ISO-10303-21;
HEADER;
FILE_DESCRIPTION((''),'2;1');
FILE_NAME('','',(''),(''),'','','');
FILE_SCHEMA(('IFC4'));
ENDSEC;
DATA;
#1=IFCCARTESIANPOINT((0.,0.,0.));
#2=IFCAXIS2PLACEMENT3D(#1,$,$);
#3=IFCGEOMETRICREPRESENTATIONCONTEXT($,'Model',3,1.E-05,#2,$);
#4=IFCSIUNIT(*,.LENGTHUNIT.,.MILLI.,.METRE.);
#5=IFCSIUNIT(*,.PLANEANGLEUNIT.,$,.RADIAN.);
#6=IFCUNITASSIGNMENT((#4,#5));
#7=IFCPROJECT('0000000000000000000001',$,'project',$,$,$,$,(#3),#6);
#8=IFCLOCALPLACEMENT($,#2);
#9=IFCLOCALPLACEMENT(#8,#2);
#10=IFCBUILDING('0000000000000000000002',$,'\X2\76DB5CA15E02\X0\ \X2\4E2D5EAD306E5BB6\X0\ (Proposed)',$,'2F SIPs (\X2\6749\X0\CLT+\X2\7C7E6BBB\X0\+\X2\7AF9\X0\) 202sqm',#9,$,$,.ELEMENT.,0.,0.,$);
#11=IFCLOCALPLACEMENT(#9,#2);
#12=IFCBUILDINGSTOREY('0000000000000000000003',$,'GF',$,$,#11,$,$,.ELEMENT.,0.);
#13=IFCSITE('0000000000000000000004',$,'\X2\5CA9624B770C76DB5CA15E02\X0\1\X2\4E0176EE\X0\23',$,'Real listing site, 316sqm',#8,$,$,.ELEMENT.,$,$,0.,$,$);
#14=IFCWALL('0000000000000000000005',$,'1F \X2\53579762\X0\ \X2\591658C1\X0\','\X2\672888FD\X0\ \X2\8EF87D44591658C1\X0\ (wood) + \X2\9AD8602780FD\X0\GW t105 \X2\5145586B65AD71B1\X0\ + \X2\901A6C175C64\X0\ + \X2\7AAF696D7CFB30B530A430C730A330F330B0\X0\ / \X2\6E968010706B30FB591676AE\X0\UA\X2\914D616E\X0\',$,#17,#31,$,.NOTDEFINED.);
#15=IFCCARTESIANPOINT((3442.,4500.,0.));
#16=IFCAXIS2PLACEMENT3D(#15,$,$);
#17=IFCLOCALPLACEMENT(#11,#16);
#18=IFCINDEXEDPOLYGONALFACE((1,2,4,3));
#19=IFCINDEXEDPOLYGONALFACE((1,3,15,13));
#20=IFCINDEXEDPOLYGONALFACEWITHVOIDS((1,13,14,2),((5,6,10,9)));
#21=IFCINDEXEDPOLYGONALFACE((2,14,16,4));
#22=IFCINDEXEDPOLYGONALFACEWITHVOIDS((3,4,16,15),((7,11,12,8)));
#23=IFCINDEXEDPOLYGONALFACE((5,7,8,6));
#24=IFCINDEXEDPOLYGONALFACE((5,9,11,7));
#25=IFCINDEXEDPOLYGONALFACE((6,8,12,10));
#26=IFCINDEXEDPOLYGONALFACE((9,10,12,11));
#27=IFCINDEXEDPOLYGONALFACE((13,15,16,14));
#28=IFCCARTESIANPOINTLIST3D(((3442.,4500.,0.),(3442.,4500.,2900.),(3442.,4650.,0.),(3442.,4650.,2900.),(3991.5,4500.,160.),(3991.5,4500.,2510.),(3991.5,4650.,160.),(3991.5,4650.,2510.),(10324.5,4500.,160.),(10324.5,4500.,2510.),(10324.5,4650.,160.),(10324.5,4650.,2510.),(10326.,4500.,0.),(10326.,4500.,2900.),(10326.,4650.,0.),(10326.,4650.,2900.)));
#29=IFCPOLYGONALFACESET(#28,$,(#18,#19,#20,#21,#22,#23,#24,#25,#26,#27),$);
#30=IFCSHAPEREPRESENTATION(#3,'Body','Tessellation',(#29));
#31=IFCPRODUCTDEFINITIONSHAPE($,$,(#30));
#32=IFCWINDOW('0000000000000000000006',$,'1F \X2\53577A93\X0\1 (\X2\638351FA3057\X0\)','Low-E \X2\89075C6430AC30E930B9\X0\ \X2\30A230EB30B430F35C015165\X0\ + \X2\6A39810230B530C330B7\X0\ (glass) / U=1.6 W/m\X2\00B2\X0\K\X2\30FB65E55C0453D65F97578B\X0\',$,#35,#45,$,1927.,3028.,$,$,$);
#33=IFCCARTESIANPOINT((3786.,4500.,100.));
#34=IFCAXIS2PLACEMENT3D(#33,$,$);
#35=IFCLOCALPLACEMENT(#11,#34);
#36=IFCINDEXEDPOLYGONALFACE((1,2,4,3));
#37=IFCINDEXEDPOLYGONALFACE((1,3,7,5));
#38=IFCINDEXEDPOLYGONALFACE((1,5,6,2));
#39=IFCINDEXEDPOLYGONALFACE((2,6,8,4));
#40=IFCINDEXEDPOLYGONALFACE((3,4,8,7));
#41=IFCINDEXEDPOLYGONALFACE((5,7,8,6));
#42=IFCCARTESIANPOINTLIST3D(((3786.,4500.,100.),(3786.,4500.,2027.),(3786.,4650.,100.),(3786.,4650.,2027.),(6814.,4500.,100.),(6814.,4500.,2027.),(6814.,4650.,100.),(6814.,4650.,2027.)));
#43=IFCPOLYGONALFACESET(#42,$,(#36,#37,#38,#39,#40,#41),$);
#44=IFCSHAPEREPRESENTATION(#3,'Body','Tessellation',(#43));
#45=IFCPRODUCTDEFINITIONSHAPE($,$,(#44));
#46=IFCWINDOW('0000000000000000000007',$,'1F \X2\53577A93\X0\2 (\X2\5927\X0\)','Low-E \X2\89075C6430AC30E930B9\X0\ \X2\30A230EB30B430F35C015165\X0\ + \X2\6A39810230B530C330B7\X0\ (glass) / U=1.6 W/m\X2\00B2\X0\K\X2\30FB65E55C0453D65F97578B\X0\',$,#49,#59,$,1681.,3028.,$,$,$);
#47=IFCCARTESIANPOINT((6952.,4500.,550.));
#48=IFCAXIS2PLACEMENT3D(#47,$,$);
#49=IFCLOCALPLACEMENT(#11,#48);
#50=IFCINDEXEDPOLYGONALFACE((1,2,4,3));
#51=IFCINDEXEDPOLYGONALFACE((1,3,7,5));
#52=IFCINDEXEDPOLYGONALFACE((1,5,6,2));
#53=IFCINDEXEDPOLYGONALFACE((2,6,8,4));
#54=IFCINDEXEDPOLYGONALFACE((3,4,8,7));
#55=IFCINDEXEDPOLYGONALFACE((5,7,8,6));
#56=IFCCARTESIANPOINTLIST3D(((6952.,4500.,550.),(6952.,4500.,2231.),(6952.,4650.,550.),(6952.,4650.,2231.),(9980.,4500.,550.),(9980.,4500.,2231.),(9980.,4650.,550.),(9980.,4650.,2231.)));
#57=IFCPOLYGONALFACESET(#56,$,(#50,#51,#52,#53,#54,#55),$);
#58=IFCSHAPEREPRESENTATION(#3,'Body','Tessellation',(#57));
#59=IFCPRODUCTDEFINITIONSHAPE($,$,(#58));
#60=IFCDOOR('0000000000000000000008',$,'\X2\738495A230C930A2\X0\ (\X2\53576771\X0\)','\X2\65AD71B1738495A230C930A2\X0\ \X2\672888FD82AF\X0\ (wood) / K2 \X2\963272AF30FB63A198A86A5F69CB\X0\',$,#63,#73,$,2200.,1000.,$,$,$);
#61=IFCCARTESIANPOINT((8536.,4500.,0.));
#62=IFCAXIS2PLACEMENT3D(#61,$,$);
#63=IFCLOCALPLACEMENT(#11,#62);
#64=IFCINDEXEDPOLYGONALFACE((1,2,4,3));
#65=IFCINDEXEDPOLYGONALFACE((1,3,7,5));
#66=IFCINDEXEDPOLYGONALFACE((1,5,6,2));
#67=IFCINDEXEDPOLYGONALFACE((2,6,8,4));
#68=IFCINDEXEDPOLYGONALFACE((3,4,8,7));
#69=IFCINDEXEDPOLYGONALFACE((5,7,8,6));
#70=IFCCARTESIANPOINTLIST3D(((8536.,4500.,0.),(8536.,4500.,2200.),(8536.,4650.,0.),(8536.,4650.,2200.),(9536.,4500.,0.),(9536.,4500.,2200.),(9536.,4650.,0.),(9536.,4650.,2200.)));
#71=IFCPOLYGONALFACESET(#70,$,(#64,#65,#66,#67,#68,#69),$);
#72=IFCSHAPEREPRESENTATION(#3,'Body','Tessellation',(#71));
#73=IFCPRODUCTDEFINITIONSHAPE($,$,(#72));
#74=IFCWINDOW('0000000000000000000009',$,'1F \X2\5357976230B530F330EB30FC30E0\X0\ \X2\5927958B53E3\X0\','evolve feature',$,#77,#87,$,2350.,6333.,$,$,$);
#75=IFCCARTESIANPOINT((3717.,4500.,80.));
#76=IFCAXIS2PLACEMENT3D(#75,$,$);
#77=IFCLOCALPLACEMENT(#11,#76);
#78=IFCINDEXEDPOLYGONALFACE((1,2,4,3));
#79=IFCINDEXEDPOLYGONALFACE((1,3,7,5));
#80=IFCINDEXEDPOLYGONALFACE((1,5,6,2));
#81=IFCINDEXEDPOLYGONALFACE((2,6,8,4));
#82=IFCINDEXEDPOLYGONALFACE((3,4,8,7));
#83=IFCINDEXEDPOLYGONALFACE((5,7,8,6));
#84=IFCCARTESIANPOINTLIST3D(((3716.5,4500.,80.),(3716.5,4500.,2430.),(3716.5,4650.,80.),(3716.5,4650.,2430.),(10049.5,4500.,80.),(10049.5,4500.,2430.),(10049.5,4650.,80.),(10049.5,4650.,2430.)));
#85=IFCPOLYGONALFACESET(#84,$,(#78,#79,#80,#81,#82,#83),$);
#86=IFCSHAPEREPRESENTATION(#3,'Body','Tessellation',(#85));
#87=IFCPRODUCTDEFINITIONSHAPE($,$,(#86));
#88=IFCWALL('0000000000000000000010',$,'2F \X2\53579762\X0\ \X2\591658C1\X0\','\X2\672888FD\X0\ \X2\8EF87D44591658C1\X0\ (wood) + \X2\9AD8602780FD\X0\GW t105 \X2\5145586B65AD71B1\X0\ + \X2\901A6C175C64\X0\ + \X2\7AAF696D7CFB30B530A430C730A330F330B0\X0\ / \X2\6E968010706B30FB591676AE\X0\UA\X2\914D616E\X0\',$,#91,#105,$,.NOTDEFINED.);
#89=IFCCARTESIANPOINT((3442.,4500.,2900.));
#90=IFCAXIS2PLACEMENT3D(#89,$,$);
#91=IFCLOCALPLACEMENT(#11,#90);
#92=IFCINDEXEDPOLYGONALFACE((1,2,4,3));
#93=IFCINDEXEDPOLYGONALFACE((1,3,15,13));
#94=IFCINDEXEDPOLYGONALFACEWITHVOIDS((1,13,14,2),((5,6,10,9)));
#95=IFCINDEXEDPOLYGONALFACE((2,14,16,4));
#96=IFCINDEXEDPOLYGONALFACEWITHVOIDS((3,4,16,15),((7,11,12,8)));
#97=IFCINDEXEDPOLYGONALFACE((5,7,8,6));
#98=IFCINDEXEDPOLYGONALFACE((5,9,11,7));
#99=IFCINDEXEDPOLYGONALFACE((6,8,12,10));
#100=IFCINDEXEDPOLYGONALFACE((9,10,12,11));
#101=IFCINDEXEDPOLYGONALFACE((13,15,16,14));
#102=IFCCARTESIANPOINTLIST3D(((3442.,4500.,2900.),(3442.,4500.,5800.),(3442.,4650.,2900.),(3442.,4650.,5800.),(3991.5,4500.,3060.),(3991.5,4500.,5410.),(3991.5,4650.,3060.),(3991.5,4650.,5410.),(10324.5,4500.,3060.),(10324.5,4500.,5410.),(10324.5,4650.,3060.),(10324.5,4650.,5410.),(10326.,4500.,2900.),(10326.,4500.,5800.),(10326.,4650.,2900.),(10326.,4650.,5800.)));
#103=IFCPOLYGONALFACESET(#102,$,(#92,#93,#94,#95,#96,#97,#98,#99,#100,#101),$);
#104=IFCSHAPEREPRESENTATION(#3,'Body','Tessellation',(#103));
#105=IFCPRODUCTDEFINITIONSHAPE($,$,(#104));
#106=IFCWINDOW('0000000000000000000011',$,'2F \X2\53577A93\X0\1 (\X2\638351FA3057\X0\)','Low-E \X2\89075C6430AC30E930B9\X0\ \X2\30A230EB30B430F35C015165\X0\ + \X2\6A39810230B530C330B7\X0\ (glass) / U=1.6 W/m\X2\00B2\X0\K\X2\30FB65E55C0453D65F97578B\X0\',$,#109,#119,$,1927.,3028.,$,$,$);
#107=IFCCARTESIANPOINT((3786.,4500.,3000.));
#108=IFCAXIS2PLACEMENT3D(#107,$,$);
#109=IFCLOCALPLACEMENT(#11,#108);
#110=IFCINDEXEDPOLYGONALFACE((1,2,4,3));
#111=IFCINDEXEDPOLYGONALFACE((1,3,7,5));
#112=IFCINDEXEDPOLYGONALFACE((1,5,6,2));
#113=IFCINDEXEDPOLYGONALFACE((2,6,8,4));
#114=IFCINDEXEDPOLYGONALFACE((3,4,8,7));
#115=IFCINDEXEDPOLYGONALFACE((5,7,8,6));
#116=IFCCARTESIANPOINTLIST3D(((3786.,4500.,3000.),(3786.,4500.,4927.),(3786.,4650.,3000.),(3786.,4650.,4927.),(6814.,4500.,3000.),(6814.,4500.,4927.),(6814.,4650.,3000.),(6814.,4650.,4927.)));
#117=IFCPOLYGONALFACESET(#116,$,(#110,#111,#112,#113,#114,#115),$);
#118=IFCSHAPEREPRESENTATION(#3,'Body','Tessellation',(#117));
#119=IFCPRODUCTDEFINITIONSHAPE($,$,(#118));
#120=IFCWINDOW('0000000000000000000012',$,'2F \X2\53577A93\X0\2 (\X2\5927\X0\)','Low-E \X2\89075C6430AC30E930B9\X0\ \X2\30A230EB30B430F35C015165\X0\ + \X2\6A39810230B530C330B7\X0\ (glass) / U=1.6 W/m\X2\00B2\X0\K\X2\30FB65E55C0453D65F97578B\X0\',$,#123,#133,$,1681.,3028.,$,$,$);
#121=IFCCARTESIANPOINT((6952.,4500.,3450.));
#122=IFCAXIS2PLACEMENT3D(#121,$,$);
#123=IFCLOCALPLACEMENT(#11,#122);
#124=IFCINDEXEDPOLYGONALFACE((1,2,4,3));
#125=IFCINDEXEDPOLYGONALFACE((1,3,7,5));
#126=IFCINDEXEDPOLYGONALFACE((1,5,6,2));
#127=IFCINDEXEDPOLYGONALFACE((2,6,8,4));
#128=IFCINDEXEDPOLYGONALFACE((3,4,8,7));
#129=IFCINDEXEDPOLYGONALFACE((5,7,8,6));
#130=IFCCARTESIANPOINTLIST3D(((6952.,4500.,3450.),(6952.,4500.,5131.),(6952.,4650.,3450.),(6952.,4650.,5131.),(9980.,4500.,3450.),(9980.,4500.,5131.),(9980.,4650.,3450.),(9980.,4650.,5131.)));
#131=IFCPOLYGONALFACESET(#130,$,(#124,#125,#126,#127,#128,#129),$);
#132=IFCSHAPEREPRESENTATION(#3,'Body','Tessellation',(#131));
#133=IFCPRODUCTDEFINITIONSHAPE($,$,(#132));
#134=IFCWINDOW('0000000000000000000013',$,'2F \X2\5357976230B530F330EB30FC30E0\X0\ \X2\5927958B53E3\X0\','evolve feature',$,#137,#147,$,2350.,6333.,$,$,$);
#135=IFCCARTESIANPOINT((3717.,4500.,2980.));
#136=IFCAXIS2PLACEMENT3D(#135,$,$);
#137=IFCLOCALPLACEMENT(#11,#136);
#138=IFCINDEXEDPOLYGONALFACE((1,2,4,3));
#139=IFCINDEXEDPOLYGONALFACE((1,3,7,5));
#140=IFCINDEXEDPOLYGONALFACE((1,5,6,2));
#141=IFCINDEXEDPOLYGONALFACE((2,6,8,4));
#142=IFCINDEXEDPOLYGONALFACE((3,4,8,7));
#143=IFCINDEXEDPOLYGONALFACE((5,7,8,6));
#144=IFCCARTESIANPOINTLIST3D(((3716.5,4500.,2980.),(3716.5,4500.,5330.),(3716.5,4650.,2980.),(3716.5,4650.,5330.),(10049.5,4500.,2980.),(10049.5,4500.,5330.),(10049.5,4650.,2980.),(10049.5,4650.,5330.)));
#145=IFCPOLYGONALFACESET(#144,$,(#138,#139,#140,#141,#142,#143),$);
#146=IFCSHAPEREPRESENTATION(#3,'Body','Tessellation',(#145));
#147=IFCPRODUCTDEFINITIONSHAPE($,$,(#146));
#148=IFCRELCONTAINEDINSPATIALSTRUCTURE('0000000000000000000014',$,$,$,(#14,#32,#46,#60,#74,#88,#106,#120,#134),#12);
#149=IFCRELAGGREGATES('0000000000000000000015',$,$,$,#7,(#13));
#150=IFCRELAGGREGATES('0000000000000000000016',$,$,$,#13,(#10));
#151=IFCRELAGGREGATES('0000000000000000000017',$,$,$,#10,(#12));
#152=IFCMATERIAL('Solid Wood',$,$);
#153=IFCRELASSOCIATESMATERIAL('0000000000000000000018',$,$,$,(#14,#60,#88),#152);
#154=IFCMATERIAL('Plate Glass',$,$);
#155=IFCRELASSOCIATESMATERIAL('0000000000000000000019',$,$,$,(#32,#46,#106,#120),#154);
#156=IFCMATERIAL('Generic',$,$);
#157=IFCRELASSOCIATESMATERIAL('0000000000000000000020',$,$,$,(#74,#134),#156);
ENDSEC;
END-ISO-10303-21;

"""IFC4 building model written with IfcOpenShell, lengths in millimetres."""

from ifc_helpers import new_model, si_unit, frame, frame_2d, origin, place, context, project, spatial, rectangle, extrude, material, element, fill, save


model = new_model("IFC4")

# Units and contexts
model_context = context("Model", 3, precision=1e-05, world=origin())
ifc_project = project(units=[si_unit("LENGTHUNIT", "METRE", prefix="MILLI"), si_unit("PLANEANGLEUNIT", "RADIAN")], contexts=[model_context])

# Site, building, storey
site_placement = place(None, origin())
site = spatial("IfcSite", under=ifc_project, at=site_placement, Name="岩手県盛岡市1丁目23", ObjectType="Real listing site, 316sqm", CompositionType="ELEMENT", RefElevation=0.0)
building_placement = place(site_placement, origin())
building = spatial("IfcBuilding", under=site, at=building_placement, Name="盛岡市 中庭の家 (Proposed)", ObjectType="2F SIPs (杉CLT+籾殻+竹) 202sqm", CompositionType="ELEMENT", ElevationOfRefHeight=0.0, ElevationOfTerrain=0.0)
storey_placement = place(building_placement, origin())
storey = spatial("IfcBuildingStorey", under=building, at=storey_placement, Name="GF", CompositionType="ELEMENT", Elevation=0.0)

# Shared definitions
ifc_material_1 = material(Name="Solid Wood")

# Wall, openings, windows, door
wall_1_placement = place(storey_placement, frame((3442.0, 4500.0, 0.0)))
wall_1 = element("IfcWall", 1, at=wall_1_placement, inside=storey, material=ifc_material_1, Name="1F 南面 外壁", Description="木製 軸組外壁 (wood) + 高性能GW t105 充填断熱 + 通気層 + 窯業系サイディング / 準耐火・外皮UA配慮", PredefinedType="NOTDEFINED", context=model_context, shape_type="SweptSolid", body=[
    extrude(rectangle(XDim=6884.0, YDim=150.0, at=frame_2d((3442.0, 75.0))), frame((3442.0, 4500.0, 0.0)), (0.0, 0.0, 1.0), 2900.0),
])
opening_1_placement = place(storey_placement, frame((3786.0, 4500.0, 100.0)))
opening_1 = element("IfcOpeningElement", 2, at=opening_1_placement, cuts=wall_1, PredefinedType="NOTDEFINED", context=model_context, shape_type="SweptSolid", body=[
    extrude(rectangle(XDim=3028.0, YDim=150.0, at=frame_2d((1514.0, 75.0))), frame((3786.0, 4500.0, 100.0)), (0.0, 0.0, 1.0), 1927.0),
])
opening_2_placement = place(storey_placement, frame((6952.0, 4500.0, 550.0)))
opening_2 = element("IfcOpeningElement", 3, at=opening_2_placement, cuts=wall_1, PredefinedType="NOTDEFINED", context=model_context, shape_type="SweptSolid", body=[
    extrude(rectangle(XDim=3028.0, YDim=150.0, at=frame_2d((1514.0, 75.0))), frame((6952.0, 4500.0, 550.0)), (0.0, 0.0, 1.0), 1681.0),
])
opening_3_placement = place(storey_placement, frame((8536.0, 4500.0, 0.0)))
opening_3 = element("IfcOpeningElement", 4, at=opening_3_placement, cuts=wall_1, PredefinedType="NOTDEFINED", context=model_context, shape_type="SweptSolid", body=[
    extrude(rectangle(XDim=1000.0, YDim=150.0, at=frame_2d((500.0, 75.0))), frame((8536.0, 4500.0, 0.0)), (0.0, 0.0, 1.0), 2200.0),
])
opening_4_placement = place(storey_placement, frame((3717.0, 4500.0, 80.0)))
opening_4 = element("IfcOpeningElement", 5, at=opening_4_placement, cuts=wall_1, PredefinedType="NOTDEFINED", context=model_context, shape_type="SweptSolid", body=[
    extrude(rectangle(XDim=6333.0, YDim=150.0, at=frame_2d((3166.0, 75.0))), frame((3717.0, 4500.0, 80.0)), (0.0, 0.0, 1.0), 2350.0),
])
ifc_material_2 = material(Name="Plate Glass")
window_1_placement = place(storey_placement, frame((3786.0, 4500.0, 100.0)))
window_1 = element("IfcWindow", 6, at=window_1_placement, inside=storey, material=ifc_material_2, Name="1F 南窓1 (掃出し)", Description="Low-E 複層ガラス アルゴン封入 + 樹脂サッシ (glass) / U=1.6 W/m²K・日射取得型", OverallHeight=1927.0, OverallWidth=3028.0, context=model_context, shape_type="SweptSolid", body=[
    extrude(rectangle(XDim=3028.0, YDim=150.0, at=frame_2d((1514.0, 75.0))), frame((3786.0, 4500.0, 100.0)), (0.0, 0.0, 1.0), 1927.0),
])
fill(opening_1, window_1)
window_2_placement = place(storey_placement, frame((6952.0, 4500.0, 550.0)))
window_2 = element("IfcWindow", 7, at=window_2_placement, inside=storey, material=ifc_material_2, Name="1F 南窓2 (大)", Description="Low-E 複層ガラス アルゴン封入 + 樹脂サッシ (glass) / U=1.6 W/m²K・日射取得型", OverallHeight=1681.0, OverallWidth=3028.0, context=model_context, shape_type="SweptSolid", body=[
    extrude(rectangle(XDim=3028.0, YDim=150.0, at=frame_2d((1514.0, 75.0))), frame((6952.0, 4500.0, 550.0)), (0.0, 0.0, 1.0), 1681.0),
])
fill(opening_2, window_2)
door_placement = place(storey_placement, frame((8536.0, 4500.0, 0.0)))
door = element("IfcDoor", 8, at=door_placement, inside=storey, material=ifc_material_1, Name="玄関ドア (南東)", Description="断熱玄関ドア 木製芯 (wood) / K2 防犯・採風機構", OverallHeight=2200.0, OverallWidth=1000.0, context=model_context, shape_type="SweptSolid", body=[
    extrude(rectangle(XDim=1000.0, YDim=150.0, at=frame_2d((500.0, 75.0))), frame((8536.0, 4500.0, 0.0)), (0.0, 0.0, 1.0), 2200.0),
])
fill(opening_3, door)
ifc_material_3 = material(Name="Generic")
window_3_placement = place(storey_placement, frame((3717.0, 4500.0, 80.0)))
window_3 = element("IfcWindow", 9, at=window_3_placement, inside=storey, material=ifc_material_3, Name="1F 南面サンルーム 大開口", Description="evolve feature", OverallHeight=2350.0, OverallWidth=6333.0, context=model_context, shape_type="SweptSolid", body=[
    extrude(rectangle(XDim=6333.0, YDim=150.0, at=frame_2d((3166.0, 75.0))), frame((3717.0, 4500.0, 80.0)), (0.0, 0.0, 1.0), 2350.0),
])
fill(opening_4, window_3)

# Wall, openings, windows
wall_2_placement = place(storey_placement, frame((3442.0, 4500.0, 2900.0)))
wall_2 = element("IfcWall", 10, at=wall_2_placement, inside=storey, material=ifc_material_1, Name="2F 南面 外壁", Description="木製 軸組外壁 (wood) + 高性能GW t105 充填断熱 + 通気層 + 窯業系サイディング / 準耐火・外皮UA配慮", PredefinedType="NOTDEFINED", context=model_context, shape_type="SweptSolid", body=[
    extrude(rectangle(XDim=6884.0, YDim=150.0, at=frame_2d((3442.0, 75.0))), frame((3442.0, 4500.0, 2900.0)), (0.0, 0.0, 1.0), 2900.0),
])
opening_5_placement = place(storey_placement, frame((3786.0, 4500.0, 3000.0)))
opening_5 = element("IfcOpeningElement", 11, at=opening_5_placement, cuts=wall_2, PredefinedType="NOTDEFINED", context=model_context, shape_type="SweptSolid", body=[
    extrude(rectangle(XDim=3028.0, YDim=150.0, at=frame_2d((1514.0, 75.0))), frame((3786.0, 4500.0, 3000.0)), (0.0, 0.0, 1.0), 1927.0),
])
opening_6_placement = place(storey_placement, frame((6952.0, 4500.0, 3450.0)))
opening_6 = element("IfcOpeningElement", 12, at=opening_6_placement, cuts=wall_2, PredefinedType="NOTDEFINED", context=model_context, shape_type="SweptSolid", body=[
    extrude(rectangle(XDim=3028.0, YDim=150.0, at=frame_2d((1514.0, 75.0))), frame((6952.0, 4500.0, 3450.0)), (0.0, 0.0, 1.0), 1681.0),
])
opening_7_placement = place(storey_placement, frame((3717.0, 4500.0, 2980.0)))
opening_7 = element("IfcOpeningElement", 13, at=opening_7_placement, cuts=wall_2, PredefinedType="NOTDEFINED", context=model_context, shape_type="SweptSolid", body=[
    extrude(rectangle(XDim=6333.0, YDim=150.0, at=frame_2d((3166.0, 75.0))), frame((3717.0, 4500.0, 2980.0)), (0.0, 0.0, 1.0), 2350.0),
])
window_4_placement = place(storey_placement, frame((3786.0, 4500.0, 3000.0)))
window_4 = element("IfcWindow", 14, at=window_4_placement, inside=storey, material=ifc_material_2, Name="2F 南窓1 (掃出し)", Description="Low-E 複層ガラス アルゴン封入 + 樹脂サッシ (glass) / U=1.6 W/m²K・日射取得型", OverallHeight=1927.0, OverallWidth=3028.0, context=model_context, shape_type="SweptSolid", body=[
    extrude(rectangle(XDim=3028.0, YDim=150.0, at=frame_2d((1514.0, 75.0))), frame((3786.0, 4500.0, 3000.0)), (0.0, 0.0, 1.0), 1927.0),
])
fill(opening_5, window_4)
window_5_placement = place(storey_placement, frame((6952.0, 4500.0, 3450.0)))
window_5 = element("IfcWindow", 15, at=window_5_placement, inside=storey, material=ifc_material_2, Name="2F 南窓2 (大)", Description="Low-E 複層ガラス アルゴン封入 + 樹脂サッシ (glass) / U=1.6 W/m²K・日射取得型", OverallHeight=1681.0, OverallWidth=3028.0, context=model_context, shape_type="SweptSolid", body=[
    extrude(rectangle(XDim=3028.0, YDim=150.0, at=frame_2d((1514.0, 75.0))), frame((6952.0, 4500.0, 3450.0)), (0.0, 0.0, 1.0), 1681.0),
])
fill(opening_6, window_5)
window_6_placement = place(storey_placement, frame((3717.0, 4500.0, 2980.0)))
window_6 = element("IfcWindow", 16, at=window_6_placement, inside=storey, material=ifc_material_3, Name="2F 南面サンルーム 大開口", Description="evolve feature", OverallHeight=2350.0, OverallWidth=6333.0, context=model_context, shape_type="SweptSolid", body=[
    extrude(rectangle(XDim=6333.0, YDim=150.0, at=frame_2d((3166.0, 75.0))), frame((3717.0, 4500.0, 2980.0)), (0.0, 0.0, 1.0), 2350.0),
])
fill(opening_7, window_6)

save(model, "model.ifc")
